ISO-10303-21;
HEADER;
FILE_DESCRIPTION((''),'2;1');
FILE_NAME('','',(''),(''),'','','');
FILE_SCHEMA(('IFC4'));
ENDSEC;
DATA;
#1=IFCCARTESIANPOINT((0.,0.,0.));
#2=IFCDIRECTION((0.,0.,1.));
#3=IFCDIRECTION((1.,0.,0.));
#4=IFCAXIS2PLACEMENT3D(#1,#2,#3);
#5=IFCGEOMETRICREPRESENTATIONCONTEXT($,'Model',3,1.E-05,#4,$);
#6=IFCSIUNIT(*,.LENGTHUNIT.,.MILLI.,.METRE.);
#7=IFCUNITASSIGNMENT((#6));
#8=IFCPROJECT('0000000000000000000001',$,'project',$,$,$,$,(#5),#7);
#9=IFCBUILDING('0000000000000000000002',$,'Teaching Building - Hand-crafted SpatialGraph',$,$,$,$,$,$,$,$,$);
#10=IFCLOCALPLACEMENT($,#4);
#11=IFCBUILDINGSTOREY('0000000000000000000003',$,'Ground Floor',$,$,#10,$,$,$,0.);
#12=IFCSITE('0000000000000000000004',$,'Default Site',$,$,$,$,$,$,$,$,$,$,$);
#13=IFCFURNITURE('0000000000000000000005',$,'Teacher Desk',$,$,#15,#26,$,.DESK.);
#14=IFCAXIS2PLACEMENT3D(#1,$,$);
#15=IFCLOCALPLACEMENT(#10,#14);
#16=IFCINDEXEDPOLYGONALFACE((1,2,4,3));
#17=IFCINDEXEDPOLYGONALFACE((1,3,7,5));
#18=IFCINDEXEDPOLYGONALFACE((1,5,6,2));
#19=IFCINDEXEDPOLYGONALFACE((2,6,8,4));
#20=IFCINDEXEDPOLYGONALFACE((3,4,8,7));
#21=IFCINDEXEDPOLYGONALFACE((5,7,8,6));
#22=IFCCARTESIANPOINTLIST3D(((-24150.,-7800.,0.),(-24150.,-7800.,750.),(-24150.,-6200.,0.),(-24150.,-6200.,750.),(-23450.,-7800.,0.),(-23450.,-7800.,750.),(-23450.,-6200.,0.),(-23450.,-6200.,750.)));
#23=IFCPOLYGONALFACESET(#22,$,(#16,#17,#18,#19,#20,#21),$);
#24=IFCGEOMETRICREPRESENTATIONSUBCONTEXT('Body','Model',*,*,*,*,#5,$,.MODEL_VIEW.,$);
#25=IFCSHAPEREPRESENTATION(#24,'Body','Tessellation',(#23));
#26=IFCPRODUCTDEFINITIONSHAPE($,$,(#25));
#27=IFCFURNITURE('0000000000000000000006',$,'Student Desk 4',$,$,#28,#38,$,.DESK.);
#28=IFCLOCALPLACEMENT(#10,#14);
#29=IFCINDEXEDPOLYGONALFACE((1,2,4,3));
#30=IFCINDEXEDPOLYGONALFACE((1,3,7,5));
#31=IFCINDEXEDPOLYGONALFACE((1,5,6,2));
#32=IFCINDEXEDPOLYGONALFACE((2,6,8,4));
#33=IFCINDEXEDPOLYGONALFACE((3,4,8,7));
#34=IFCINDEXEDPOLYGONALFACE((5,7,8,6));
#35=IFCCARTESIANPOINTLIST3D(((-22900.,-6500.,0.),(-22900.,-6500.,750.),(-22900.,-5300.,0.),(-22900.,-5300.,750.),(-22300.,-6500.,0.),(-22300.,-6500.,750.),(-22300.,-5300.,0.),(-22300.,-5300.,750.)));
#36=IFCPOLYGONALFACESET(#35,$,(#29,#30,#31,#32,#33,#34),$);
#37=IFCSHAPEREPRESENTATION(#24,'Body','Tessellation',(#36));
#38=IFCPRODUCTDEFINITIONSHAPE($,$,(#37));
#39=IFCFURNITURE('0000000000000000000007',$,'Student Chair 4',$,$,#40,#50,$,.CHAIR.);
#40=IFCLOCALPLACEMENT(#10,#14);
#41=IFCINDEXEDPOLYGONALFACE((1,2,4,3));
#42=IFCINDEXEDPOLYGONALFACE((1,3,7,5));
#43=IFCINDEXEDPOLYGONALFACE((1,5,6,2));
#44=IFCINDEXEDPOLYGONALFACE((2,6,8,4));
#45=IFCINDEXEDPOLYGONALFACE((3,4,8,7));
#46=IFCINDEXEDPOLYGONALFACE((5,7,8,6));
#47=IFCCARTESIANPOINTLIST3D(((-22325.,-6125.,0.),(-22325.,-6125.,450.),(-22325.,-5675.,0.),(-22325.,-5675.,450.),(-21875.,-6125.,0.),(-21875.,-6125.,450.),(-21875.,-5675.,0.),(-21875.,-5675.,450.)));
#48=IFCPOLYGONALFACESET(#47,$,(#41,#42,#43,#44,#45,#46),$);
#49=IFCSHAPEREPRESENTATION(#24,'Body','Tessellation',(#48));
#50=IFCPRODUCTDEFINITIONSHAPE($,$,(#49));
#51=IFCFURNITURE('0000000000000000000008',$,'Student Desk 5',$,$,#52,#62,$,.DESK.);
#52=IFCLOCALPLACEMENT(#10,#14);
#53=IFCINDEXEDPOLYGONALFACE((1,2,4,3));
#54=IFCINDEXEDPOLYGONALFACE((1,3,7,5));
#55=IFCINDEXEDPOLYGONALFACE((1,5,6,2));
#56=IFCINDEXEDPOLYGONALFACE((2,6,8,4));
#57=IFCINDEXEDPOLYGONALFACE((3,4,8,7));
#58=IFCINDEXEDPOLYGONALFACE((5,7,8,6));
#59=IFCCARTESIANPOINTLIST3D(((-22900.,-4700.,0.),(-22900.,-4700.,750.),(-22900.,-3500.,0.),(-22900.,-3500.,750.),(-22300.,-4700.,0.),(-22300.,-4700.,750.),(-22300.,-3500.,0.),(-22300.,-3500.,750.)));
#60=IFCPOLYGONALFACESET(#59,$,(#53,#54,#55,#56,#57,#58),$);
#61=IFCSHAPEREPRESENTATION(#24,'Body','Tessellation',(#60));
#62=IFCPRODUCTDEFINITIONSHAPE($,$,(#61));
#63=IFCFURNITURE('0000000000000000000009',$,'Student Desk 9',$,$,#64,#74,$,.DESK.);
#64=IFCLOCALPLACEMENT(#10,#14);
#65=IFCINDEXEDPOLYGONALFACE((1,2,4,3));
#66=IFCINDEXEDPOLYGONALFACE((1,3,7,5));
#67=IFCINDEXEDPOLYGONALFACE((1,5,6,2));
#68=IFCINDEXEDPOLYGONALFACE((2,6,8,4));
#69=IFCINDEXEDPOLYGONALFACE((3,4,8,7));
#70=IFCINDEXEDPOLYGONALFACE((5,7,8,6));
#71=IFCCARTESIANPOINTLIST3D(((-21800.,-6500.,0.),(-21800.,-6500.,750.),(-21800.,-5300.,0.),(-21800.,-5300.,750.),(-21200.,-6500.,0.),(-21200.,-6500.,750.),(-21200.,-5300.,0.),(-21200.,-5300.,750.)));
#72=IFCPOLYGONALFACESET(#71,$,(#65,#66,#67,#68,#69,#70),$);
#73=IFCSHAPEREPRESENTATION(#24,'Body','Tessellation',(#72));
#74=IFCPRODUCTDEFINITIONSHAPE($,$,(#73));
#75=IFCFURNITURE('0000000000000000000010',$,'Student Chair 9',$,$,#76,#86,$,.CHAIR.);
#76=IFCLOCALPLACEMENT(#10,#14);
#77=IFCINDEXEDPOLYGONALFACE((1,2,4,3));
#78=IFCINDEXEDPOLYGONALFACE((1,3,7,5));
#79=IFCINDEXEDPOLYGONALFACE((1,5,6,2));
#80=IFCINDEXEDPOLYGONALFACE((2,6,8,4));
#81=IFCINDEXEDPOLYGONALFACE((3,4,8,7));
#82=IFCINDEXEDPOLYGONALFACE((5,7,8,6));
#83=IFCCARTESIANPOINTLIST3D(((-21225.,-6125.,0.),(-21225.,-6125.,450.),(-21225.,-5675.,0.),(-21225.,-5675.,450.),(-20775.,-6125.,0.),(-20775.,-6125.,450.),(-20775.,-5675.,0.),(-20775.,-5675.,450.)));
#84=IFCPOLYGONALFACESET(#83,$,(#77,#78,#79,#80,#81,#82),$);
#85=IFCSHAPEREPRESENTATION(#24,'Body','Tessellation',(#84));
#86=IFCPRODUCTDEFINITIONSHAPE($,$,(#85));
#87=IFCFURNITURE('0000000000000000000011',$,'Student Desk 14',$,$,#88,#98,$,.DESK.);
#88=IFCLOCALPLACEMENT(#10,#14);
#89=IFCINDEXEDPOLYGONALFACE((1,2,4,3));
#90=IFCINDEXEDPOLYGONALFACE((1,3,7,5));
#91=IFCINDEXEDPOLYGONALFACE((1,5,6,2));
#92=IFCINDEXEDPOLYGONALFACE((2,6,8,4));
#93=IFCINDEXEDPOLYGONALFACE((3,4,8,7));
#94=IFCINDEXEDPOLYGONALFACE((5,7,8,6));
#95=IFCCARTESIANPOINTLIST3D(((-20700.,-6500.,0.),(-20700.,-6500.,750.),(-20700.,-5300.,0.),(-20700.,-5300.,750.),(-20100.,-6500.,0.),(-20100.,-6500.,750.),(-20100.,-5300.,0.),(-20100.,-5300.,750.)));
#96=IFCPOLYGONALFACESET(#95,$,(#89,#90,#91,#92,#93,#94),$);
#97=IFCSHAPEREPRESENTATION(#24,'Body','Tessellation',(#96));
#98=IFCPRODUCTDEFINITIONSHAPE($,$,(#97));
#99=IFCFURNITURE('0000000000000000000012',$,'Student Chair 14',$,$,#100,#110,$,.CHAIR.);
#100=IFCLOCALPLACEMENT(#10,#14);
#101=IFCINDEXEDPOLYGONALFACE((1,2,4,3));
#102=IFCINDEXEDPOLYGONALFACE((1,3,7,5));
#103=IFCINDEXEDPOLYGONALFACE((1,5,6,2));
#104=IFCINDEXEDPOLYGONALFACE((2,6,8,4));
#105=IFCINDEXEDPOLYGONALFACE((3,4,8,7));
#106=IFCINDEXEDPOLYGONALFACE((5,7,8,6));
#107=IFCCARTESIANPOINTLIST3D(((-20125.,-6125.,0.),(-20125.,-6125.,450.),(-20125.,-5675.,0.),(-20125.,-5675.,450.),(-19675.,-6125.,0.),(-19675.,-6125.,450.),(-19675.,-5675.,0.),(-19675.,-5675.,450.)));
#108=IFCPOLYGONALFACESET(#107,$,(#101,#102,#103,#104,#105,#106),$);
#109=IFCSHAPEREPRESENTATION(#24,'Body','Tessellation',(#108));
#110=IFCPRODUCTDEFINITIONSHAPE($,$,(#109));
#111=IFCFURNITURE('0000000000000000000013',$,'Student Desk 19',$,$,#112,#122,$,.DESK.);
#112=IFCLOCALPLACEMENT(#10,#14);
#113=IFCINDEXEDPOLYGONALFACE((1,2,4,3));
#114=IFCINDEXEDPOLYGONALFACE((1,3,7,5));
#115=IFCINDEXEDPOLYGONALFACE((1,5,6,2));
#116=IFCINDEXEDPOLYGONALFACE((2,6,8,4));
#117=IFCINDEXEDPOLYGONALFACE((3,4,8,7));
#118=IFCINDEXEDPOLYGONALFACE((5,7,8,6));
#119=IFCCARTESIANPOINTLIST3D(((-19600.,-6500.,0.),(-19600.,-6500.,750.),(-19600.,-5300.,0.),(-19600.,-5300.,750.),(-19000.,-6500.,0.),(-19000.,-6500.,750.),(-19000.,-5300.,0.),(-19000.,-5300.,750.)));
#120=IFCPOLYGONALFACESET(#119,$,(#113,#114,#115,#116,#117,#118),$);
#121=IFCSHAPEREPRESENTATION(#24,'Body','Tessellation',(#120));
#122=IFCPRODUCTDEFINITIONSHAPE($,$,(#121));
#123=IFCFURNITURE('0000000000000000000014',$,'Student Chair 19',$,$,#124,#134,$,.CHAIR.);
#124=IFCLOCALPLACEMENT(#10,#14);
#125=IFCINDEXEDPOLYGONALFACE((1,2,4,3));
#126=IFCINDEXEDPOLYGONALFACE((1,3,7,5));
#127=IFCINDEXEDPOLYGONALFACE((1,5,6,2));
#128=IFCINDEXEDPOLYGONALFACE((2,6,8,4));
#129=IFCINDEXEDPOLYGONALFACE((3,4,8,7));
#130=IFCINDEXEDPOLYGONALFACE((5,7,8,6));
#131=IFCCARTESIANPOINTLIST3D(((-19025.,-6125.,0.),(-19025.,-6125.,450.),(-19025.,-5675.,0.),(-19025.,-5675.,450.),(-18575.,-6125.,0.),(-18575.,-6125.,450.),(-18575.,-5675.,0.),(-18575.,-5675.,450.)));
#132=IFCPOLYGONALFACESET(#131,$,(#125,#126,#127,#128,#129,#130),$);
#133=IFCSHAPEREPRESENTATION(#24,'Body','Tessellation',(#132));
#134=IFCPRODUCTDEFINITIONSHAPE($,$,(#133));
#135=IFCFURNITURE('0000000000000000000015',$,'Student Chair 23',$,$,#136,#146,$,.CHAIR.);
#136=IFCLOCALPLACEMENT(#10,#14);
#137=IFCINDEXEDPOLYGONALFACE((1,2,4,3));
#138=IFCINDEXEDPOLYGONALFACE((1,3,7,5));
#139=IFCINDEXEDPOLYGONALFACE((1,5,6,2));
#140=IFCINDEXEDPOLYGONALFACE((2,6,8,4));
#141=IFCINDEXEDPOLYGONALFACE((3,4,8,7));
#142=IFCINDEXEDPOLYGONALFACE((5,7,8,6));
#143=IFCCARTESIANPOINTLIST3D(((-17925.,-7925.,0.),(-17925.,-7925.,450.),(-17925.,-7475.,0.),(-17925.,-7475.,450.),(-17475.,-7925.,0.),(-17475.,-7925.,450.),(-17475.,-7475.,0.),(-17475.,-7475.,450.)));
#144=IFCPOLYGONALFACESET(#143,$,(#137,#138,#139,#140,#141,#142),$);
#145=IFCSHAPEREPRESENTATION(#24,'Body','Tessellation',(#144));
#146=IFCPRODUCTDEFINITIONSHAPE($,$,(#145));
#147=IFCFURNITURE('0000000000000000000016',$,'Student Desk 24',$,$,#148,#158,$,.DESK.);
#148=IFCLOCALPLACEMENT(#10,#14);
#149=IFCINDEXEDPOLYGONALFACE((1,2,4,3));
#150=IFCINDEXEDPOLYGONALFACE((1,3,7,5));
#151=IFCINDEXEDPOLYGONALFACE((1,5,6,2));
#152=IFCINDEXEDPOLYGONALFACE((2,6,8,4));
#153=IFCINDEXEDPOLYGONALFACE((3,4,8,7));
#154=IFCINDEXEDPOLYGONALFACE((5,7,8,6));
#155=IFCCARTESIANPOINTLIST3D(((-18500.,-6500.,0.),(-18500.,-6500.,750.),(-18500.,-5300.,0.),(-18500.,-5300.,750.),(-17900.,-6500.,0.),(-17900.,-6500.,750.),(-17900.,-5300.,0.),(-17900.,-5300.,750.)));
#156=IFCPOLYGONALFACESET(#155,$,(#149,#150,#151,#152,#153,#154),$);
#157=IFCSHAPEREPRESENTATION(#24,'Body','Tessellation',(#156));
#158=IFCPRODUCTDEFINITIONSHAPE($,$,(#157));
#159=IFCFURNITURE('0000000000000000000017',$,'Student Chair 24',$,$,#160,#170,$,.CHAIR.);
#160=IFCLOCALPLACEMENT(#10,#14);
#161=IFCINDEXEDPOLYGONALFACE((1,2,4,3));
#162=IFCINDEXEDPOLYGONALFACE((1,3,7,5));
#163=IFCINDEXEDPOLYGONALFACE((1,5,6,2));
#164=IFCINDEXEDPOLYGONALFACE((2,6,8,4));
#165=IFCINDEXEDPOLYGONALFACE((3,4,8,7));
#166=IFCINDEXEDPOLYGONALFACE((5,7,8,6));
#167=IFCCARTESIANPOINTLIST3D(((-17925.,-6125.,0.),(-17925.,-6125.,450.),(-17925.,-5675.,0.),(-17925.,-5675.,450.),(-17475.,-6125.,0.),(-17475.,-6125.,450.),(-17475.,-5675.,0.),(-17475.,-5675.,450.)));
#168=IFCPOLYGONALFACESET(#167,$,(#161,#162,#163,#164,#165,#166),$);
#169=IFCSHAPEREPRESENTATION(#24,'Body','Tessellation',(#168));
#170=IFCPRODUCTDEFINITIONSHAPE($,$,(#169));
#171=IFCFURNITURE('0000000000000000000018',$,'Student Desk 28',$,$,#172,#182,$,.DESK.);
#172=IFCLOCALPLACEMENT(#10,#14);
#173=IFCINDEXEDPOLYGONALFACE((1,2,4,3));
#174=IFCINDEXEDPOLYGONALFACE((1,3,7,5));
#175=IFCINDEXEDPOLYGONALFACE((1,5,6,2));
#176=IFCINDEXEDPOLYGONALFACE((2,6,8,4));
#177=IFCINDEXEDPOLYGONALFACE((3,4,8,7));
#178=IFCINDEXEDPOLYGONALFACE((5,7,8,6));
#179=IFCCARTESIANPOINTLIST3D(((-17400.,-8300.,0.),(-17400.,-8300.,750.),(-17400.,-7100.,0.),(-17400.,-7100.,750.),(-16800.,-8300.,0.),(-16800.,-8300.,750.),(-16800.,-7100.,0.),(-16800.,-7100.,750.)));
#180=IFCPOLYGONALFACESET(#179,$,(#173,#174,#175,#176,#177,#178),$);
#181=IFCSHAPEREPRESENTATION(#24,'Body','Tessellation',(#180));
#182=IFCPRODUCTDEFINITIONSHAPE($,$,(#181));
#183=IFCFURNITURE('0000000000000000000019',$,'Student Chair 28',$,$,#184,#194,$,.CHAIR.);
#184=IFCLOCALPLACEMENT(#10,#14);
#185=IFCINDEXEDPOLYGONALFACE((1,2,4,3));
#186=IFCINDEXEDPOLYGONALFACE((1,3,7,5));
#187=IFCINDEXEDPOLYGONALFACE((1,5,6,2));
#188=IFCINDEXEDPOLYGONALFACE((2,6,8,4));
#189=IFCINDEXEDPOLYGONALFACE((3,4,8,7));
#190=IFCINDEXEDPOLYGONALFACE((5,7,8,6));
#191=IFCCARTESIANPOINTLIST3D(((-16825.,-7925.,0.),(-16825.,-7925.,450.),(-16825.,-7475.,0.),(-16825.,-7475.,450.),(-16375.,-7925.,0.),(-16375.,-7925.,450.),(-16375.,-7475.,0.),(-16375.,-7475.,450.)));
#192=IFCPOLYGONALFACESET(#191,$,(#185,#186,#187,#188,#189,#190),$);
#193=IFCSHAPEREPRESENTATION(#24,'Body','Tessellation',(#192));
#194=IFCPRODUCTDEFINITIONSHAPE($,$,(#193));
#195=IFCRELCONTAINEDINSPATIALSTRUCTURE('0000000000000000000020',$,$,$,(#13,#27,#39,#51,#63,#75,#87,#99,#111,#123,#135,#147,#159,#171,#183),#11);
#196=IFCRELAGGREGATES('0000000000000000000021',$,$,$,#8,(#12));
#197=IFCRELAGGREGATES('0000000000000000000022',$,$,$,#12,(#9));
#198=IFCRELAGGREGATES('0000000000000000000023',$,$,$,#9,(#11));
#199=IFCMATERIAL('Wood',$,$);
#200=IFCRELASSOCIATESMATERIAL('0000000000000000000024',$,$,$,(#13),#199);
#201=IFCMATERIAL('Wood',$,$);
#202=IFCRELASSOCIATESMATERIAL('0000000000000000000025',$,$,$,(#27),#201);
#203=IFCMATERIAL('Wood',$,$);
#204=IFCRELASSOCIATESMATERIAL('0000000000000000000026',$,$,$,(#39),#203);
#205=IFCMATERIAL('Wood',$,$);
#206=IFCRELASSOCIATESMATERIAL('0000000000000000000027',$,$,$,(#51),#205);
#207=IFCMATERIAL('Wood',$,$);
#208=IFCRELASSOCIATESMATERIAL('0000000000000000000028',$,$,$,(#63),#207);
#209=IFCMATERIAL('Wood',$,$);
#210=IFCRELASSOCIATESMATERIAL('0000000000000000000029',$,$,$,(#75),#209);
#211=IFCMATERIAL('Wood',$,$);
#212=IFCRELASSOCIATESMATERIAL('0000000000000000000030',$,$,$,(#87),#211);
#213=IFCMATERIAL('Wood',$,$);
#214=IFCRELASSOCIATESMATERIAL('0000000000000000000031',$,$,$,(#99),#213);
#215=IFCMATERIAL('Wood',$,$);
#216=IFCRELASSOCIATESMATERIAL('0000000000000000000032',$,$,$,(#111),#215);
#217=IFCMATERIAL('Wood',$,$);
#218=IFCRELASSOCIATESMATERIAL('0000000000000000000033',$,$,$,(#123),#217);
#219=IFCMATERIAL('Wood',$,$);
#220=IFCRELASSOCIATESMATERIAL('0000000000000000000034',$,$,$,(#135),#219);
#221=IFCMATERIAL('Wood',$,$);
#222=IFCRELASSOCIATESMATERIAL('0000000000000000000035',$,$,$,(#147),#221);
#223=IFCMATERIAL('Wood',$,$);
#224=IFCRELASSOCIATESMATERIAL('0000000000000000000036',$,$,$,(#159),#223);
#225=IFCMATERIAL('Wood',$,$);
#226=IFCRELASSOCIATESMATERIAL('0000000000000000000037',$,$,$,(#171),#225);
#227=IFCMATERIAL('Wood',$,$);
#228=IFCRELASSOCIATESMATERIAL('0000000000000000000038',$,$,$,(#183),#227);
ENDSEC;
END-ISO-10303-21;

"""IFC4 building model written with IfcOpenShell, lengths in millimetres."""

from ifc_helpers import new_model, si_unit, frame, origin_with_axes, origin_2d, place, context, subcontext, project, spatial, rectangle, extrude, material, element, save


model = new_model("IFC4")

# Units and contexts
model_context = context("Model", 3, precision=1e-05, world=origin_with_axes())
body_context = subcontext(model_context, "Body", "Model", "MODEL_VIEW")
ifc_project = project(units=[si_unit("LENGTHUNIT", "METRE", prefix="MILLI")], contexts=[model_context])

# Site, building, storey
site = spatial("IfcSite", under=ifc_project, Name="Default Site")
building = spatial("IfcBuilding", under=site, Name="Teaching Building - Hand-crafted SpatialGraph")
storey_placement = place(None, origin_with_axes())
storey = spatial("IfcBuildingStorey", under=building, at=storey_placement, Name="Ground Floor", Elevation=0.0)

# Furniture
ifc_material_1 = material(Name="Wood")
furniture_1_placement = place(storey_placement, frame((-23800.0, -7000.0, 0.0), z_axis=(0.0, 0.0, 1.0), x_axis=(0.0, 1.0, 0.0)))
element("IfcFurniture", 1, at=furniture_1_placement, inside=storey, material=ifc_material_1, Name="Teacher Desk", PredefinedType="DESK", context=body_context, shape_type="SweptSolid", body=[
    extrude(rectangle(XDim=1600.0, YDim=700.0, at=origin_2d()), origin_with_axes(), (0.0, 0.0, 1.0), 750.0),
])
ifc_material_2 = material(Name="Wood")
furniture_2_placement = place(storey_placement, frame((-22600.0, -5900.0, 0.0), z_axis=(0.0, 0.0, 1.0), x_axis=(0.0, 1.0, 0.0)))
element("IfcFurniture", 2, at=furniture_2_placement, inside=storey, material=ifc_material_2, Name="Student Desk 4", PredefinedType="DESK", context=body_context, shape_type="SweptSolid", body=[
    extrude(rectangle(XDim=1200.0, YDim=600.0, at=origin_2d()), origin_with_axes(), (0.0, 0.0, 1.0), 750.0),
])
ifc_material_3 = material(Name="Wood")
furniture_3_placement = place(storey_placement, frame((-22100.0, -5900.0, 0.0), z_axis=(0.0, 0.0, 1.0), x_axis=(1.0, 0.0, 0.0)))
element("IfcFurniture", 3, at=furniture_3_placement, inside=storey, material=ifc_material_3, Name="Student Chair 4", PredefinedType="CHAIR", context=body_context, shape_type="SweptSolid", body=[
    extrude(rectangle(XDim=450.0, YDim=450.0, at=origin_2d()), origin_with_axes(), (0.0, 0.0, 1.0), 450.0),
])
ifc_material_4 = material(Name="Wood")
furniture_4_placement = place(storey_placement, frame((-22600.0, -4100.0, 0.0), z_axis=(0.0, 0.0, 1.0), x_axis=(0.0, 1.0, 0.0)))
element("IfcFurniture", 4, at=furniture_4_placement, inside=storey, material=ifc_material_4, Name="Student Desk 5", PredefinedType="DESK", context=body_context, shape_type="SweptSolid", body=[
    extrude(rectangle(XDim=1200.0, YDim=600.0, at=origin_2d()), origin_with_axes(), (0.0, 0.0, 1.0), 750.0),
])
ifc_material_5 = material(Name="Wood")
furniture_5_placement = place(storey_placement, frame((-21500.0, -5900.0, 0.0), z_axis=(0.0, 0.0, 1.0), x_axis=(0.0, 1.0, 0.0)))
element("IfcFurniture", 5, at=furniture_5_placement, inside=storey, material=ifc_material_5, Name="Student Desk 9", PredefinedType="DESK", context=body_context, shape_type="SweptSolid", body=[
    extrude(rectangle(XDim=1200.0, YDim=600.0, at=origin_2d()), origin_with_axes(), (0.0, 0.0, 1.0), 750.0),
])
ifc_material_6 = material(Name="Wood")
furniture_6_placement = place(storey_placement, frame((-21000.0, -5900.0, 0.0), z_axis=(0.0, 0.0, 1.0), x_axis=(1.0, 0.0, 0.0)))
element("IfcFurniture", 6, at=furniture_6_placement, inside=storey, material=ifc_material_6, Name="Student Chair 9", PredefinedType="CHAIR", context=body_context, shape_type="SweptSolid", body=[
    extrude(rectangle(XDim=450.0, YDim=450.0, at=origin_2d()), origin_with_axes(), (0.0, 0.0, 1.0), 450.0),
])
ifc_material_7 = material(Name="Wood")
furniture_7_placement = place(storey_placement, frame((-20400.0, -5900.0, 0.0), z_axis=(0.0, 0.0, 1.0), x_axis=(0.0, 1.0, 0.0)))
element("IfcFurniture", 7, at=furniture_7_placement, inside=storey, material=ifc_material_7, Name="Student Desk 14", PredefinedType="DESK", context=body_context, shape_type="SweptSolid", body=[
    extrude(rectangle(XDim=1200.0, YDim=600.0, at=origin_2d()), origin_with_axes(), (0.0, 0.0, 1.0), 750.0),
])
ifc_material_8 = material(Name="Wood")
furniture_8_placement = place(storey_placement, frame((-19900.0, -5900.0, 0.0), z_axis=(0.0, 0.0, 1.0), x_axis=(1.0, 0.0, 0.0)))
element("IfcFurniture", 8, at=furniture_8_placement, inside=storey, material=ifc_material_8, Name="Student Chair 14", PredefinedType="CHAIR", context=body_context, shape_type="SweptSolid", body=[
    extrude(rectangle(XDim=450.0, YDim=450.0, at=origin_2d()), origin_with_axes(), (0.0, 0.0, 1.0), 450.0),
])
ifc_material_9 = material(Name="Wood")
furniture_9_placement = place(storey_placement, frame((-19300.0, -5900.0, 0.0), z_axis=(0.0, 0.0, 1.0), x_axis=(0.0, 1.0, 0.0)))
element("IfcFurniture", 9, at=furniture_9_placement, inside=storey, material=ifc_material_9, Name="Student Desk 19", PredefinedType="DESK", context=body_context, shape_type="SweptSolid", body=[
    extrude(rectangle(XDim=1200.0, YDim=600.0, at=origin_2d()), origin_with_axes(), (0.0, 0.0, 1.0), 750.0),
])
ifc_material_10 = material(Name="Wood")
furniture_10_placement = place(storey_placement, frame((-18800.0, -5900.0, 0.0), z_axis=(0.0, 0.0, 1.0), x_axis=(1.0, 0.0, 0.0)))
element("IfcFurniture", 10, at=furniture_10_placement, inside=storey, material=ifc_material_10, Name="Student Chair 19", PredefinedType="CHAIR", context=body_context, shape_type="SweptSolid", body=[
    extrude(rectangle(XDim=450.0, YDim=450.0, at=origin_2d()), origin_with_axes(), (0.0, 0.0, 1.0), 450.0),
])
ifc_material_11 = material(Name="Wood")
furniture_11_placement = place(storey_placement, frame((-17700.0, -7700.0, 0.0), z_axis=(0.0, 0.0, 1.0), x_axis=(1.0, 0.0, 0.0)))
element("IfcFurniture", 11, at=furniture_11_placement, inside=storey, material=ifc_material_11, Name="Student Chair 23", PredefinedType="CHAIR", context=body_context, shape_type="SweptSolid", body=[
    extrude(rectangle(XDim=450.0, YDim=450.0, at=origin_2d()), origin_with_axes(), (0.0, 0.0, 1.0), 450.0),
])
ifc_material_12 = material(Name="Wood")
furniture_12_placement = place(storey_placement, frame((-18200.0, -5900.0, 0.0), z_axis=(0.0, 0.0, 1.0), x_axis=(0.0, 1.0, 0.0)))
element("IfcFurniture", 12, at=furniture_12_placement, inside=storey, material=ifc_material_12, Name="Student Desk 24", PredefinedType="DESK", context=body_context, shape_type="SweptSolid", body=[
    extrude(rectangle(XDim=1200.0, YDim=600.0, at=origin_2d()), origin_with_axes(), (0.0, 0.0, 1.0), 750.0),
])
ifc_material_13 = material(Name="Wood")
furniture_13_placement = place(storey_placement, frame((-17700.0, -5900.0, 0.0), z_axis=(0.0, 0.0, 1.0), x_axis=(1.0, 0.0, 0.0)))
element("IfcFurniture", 13, at=furniture_13_placement, inside=storey, material=ifc_material_13, Name="Student Chair 24", PredefinedType="CHAIR", context=body_context, shape_type="SweptSolid", body=[
    extrude(rectangle(XDim=450.0, YDim=450.0, at=origin_2d()), origin_with_axes(), (0.0, 0.0, 1.0), 450.0),
])
ifc_material_14 = material(Name="Wood")
furniture_14_placement = place(storey_placement, frame((-17100.0, -7700.0, 0.0), z_axis=(0.0, 0.0, 1.0), x_axis=(0.0, 1.0, 0.0)))
element("IfcFurniture", 14, at=furniture_14_placement, inside=storey, material=ifc_material_14, Name="Student Desk 28", PredefinedType="DESK", context=body_context, shape_type="SweptSolid", body=[
    extrude(rectangle(XDim=1200.0, YDim=600.0, at=origin_2d()), origin_with_axes(), (0.0, 0.0, 1.0), 750.0),
])
ifc_material_15 = material(Name="Wood")
furniture_15_placement = place(storey_placement, frame((-16600.0, -7700.0, 0.0), z_axis=(0.0, 0.0, 1.0), x_axis=(1.0, 0.0, 0.0)))
element("IfcFurniture", 15, at=furniture_15_placement, inside=storey, material=ifc_material_15, Name="Student Chair 28", PredefinedType="CHAIR", context=body_context, shape_type="SweptSolid", body=[
    extrude(rectangle(XDim=450.0, YDim=450.0, at=origin_2d()), origin_with_axes(), (0.0, 0.0, 1.0), 450.0),
])

save(model, "model.ifc")
